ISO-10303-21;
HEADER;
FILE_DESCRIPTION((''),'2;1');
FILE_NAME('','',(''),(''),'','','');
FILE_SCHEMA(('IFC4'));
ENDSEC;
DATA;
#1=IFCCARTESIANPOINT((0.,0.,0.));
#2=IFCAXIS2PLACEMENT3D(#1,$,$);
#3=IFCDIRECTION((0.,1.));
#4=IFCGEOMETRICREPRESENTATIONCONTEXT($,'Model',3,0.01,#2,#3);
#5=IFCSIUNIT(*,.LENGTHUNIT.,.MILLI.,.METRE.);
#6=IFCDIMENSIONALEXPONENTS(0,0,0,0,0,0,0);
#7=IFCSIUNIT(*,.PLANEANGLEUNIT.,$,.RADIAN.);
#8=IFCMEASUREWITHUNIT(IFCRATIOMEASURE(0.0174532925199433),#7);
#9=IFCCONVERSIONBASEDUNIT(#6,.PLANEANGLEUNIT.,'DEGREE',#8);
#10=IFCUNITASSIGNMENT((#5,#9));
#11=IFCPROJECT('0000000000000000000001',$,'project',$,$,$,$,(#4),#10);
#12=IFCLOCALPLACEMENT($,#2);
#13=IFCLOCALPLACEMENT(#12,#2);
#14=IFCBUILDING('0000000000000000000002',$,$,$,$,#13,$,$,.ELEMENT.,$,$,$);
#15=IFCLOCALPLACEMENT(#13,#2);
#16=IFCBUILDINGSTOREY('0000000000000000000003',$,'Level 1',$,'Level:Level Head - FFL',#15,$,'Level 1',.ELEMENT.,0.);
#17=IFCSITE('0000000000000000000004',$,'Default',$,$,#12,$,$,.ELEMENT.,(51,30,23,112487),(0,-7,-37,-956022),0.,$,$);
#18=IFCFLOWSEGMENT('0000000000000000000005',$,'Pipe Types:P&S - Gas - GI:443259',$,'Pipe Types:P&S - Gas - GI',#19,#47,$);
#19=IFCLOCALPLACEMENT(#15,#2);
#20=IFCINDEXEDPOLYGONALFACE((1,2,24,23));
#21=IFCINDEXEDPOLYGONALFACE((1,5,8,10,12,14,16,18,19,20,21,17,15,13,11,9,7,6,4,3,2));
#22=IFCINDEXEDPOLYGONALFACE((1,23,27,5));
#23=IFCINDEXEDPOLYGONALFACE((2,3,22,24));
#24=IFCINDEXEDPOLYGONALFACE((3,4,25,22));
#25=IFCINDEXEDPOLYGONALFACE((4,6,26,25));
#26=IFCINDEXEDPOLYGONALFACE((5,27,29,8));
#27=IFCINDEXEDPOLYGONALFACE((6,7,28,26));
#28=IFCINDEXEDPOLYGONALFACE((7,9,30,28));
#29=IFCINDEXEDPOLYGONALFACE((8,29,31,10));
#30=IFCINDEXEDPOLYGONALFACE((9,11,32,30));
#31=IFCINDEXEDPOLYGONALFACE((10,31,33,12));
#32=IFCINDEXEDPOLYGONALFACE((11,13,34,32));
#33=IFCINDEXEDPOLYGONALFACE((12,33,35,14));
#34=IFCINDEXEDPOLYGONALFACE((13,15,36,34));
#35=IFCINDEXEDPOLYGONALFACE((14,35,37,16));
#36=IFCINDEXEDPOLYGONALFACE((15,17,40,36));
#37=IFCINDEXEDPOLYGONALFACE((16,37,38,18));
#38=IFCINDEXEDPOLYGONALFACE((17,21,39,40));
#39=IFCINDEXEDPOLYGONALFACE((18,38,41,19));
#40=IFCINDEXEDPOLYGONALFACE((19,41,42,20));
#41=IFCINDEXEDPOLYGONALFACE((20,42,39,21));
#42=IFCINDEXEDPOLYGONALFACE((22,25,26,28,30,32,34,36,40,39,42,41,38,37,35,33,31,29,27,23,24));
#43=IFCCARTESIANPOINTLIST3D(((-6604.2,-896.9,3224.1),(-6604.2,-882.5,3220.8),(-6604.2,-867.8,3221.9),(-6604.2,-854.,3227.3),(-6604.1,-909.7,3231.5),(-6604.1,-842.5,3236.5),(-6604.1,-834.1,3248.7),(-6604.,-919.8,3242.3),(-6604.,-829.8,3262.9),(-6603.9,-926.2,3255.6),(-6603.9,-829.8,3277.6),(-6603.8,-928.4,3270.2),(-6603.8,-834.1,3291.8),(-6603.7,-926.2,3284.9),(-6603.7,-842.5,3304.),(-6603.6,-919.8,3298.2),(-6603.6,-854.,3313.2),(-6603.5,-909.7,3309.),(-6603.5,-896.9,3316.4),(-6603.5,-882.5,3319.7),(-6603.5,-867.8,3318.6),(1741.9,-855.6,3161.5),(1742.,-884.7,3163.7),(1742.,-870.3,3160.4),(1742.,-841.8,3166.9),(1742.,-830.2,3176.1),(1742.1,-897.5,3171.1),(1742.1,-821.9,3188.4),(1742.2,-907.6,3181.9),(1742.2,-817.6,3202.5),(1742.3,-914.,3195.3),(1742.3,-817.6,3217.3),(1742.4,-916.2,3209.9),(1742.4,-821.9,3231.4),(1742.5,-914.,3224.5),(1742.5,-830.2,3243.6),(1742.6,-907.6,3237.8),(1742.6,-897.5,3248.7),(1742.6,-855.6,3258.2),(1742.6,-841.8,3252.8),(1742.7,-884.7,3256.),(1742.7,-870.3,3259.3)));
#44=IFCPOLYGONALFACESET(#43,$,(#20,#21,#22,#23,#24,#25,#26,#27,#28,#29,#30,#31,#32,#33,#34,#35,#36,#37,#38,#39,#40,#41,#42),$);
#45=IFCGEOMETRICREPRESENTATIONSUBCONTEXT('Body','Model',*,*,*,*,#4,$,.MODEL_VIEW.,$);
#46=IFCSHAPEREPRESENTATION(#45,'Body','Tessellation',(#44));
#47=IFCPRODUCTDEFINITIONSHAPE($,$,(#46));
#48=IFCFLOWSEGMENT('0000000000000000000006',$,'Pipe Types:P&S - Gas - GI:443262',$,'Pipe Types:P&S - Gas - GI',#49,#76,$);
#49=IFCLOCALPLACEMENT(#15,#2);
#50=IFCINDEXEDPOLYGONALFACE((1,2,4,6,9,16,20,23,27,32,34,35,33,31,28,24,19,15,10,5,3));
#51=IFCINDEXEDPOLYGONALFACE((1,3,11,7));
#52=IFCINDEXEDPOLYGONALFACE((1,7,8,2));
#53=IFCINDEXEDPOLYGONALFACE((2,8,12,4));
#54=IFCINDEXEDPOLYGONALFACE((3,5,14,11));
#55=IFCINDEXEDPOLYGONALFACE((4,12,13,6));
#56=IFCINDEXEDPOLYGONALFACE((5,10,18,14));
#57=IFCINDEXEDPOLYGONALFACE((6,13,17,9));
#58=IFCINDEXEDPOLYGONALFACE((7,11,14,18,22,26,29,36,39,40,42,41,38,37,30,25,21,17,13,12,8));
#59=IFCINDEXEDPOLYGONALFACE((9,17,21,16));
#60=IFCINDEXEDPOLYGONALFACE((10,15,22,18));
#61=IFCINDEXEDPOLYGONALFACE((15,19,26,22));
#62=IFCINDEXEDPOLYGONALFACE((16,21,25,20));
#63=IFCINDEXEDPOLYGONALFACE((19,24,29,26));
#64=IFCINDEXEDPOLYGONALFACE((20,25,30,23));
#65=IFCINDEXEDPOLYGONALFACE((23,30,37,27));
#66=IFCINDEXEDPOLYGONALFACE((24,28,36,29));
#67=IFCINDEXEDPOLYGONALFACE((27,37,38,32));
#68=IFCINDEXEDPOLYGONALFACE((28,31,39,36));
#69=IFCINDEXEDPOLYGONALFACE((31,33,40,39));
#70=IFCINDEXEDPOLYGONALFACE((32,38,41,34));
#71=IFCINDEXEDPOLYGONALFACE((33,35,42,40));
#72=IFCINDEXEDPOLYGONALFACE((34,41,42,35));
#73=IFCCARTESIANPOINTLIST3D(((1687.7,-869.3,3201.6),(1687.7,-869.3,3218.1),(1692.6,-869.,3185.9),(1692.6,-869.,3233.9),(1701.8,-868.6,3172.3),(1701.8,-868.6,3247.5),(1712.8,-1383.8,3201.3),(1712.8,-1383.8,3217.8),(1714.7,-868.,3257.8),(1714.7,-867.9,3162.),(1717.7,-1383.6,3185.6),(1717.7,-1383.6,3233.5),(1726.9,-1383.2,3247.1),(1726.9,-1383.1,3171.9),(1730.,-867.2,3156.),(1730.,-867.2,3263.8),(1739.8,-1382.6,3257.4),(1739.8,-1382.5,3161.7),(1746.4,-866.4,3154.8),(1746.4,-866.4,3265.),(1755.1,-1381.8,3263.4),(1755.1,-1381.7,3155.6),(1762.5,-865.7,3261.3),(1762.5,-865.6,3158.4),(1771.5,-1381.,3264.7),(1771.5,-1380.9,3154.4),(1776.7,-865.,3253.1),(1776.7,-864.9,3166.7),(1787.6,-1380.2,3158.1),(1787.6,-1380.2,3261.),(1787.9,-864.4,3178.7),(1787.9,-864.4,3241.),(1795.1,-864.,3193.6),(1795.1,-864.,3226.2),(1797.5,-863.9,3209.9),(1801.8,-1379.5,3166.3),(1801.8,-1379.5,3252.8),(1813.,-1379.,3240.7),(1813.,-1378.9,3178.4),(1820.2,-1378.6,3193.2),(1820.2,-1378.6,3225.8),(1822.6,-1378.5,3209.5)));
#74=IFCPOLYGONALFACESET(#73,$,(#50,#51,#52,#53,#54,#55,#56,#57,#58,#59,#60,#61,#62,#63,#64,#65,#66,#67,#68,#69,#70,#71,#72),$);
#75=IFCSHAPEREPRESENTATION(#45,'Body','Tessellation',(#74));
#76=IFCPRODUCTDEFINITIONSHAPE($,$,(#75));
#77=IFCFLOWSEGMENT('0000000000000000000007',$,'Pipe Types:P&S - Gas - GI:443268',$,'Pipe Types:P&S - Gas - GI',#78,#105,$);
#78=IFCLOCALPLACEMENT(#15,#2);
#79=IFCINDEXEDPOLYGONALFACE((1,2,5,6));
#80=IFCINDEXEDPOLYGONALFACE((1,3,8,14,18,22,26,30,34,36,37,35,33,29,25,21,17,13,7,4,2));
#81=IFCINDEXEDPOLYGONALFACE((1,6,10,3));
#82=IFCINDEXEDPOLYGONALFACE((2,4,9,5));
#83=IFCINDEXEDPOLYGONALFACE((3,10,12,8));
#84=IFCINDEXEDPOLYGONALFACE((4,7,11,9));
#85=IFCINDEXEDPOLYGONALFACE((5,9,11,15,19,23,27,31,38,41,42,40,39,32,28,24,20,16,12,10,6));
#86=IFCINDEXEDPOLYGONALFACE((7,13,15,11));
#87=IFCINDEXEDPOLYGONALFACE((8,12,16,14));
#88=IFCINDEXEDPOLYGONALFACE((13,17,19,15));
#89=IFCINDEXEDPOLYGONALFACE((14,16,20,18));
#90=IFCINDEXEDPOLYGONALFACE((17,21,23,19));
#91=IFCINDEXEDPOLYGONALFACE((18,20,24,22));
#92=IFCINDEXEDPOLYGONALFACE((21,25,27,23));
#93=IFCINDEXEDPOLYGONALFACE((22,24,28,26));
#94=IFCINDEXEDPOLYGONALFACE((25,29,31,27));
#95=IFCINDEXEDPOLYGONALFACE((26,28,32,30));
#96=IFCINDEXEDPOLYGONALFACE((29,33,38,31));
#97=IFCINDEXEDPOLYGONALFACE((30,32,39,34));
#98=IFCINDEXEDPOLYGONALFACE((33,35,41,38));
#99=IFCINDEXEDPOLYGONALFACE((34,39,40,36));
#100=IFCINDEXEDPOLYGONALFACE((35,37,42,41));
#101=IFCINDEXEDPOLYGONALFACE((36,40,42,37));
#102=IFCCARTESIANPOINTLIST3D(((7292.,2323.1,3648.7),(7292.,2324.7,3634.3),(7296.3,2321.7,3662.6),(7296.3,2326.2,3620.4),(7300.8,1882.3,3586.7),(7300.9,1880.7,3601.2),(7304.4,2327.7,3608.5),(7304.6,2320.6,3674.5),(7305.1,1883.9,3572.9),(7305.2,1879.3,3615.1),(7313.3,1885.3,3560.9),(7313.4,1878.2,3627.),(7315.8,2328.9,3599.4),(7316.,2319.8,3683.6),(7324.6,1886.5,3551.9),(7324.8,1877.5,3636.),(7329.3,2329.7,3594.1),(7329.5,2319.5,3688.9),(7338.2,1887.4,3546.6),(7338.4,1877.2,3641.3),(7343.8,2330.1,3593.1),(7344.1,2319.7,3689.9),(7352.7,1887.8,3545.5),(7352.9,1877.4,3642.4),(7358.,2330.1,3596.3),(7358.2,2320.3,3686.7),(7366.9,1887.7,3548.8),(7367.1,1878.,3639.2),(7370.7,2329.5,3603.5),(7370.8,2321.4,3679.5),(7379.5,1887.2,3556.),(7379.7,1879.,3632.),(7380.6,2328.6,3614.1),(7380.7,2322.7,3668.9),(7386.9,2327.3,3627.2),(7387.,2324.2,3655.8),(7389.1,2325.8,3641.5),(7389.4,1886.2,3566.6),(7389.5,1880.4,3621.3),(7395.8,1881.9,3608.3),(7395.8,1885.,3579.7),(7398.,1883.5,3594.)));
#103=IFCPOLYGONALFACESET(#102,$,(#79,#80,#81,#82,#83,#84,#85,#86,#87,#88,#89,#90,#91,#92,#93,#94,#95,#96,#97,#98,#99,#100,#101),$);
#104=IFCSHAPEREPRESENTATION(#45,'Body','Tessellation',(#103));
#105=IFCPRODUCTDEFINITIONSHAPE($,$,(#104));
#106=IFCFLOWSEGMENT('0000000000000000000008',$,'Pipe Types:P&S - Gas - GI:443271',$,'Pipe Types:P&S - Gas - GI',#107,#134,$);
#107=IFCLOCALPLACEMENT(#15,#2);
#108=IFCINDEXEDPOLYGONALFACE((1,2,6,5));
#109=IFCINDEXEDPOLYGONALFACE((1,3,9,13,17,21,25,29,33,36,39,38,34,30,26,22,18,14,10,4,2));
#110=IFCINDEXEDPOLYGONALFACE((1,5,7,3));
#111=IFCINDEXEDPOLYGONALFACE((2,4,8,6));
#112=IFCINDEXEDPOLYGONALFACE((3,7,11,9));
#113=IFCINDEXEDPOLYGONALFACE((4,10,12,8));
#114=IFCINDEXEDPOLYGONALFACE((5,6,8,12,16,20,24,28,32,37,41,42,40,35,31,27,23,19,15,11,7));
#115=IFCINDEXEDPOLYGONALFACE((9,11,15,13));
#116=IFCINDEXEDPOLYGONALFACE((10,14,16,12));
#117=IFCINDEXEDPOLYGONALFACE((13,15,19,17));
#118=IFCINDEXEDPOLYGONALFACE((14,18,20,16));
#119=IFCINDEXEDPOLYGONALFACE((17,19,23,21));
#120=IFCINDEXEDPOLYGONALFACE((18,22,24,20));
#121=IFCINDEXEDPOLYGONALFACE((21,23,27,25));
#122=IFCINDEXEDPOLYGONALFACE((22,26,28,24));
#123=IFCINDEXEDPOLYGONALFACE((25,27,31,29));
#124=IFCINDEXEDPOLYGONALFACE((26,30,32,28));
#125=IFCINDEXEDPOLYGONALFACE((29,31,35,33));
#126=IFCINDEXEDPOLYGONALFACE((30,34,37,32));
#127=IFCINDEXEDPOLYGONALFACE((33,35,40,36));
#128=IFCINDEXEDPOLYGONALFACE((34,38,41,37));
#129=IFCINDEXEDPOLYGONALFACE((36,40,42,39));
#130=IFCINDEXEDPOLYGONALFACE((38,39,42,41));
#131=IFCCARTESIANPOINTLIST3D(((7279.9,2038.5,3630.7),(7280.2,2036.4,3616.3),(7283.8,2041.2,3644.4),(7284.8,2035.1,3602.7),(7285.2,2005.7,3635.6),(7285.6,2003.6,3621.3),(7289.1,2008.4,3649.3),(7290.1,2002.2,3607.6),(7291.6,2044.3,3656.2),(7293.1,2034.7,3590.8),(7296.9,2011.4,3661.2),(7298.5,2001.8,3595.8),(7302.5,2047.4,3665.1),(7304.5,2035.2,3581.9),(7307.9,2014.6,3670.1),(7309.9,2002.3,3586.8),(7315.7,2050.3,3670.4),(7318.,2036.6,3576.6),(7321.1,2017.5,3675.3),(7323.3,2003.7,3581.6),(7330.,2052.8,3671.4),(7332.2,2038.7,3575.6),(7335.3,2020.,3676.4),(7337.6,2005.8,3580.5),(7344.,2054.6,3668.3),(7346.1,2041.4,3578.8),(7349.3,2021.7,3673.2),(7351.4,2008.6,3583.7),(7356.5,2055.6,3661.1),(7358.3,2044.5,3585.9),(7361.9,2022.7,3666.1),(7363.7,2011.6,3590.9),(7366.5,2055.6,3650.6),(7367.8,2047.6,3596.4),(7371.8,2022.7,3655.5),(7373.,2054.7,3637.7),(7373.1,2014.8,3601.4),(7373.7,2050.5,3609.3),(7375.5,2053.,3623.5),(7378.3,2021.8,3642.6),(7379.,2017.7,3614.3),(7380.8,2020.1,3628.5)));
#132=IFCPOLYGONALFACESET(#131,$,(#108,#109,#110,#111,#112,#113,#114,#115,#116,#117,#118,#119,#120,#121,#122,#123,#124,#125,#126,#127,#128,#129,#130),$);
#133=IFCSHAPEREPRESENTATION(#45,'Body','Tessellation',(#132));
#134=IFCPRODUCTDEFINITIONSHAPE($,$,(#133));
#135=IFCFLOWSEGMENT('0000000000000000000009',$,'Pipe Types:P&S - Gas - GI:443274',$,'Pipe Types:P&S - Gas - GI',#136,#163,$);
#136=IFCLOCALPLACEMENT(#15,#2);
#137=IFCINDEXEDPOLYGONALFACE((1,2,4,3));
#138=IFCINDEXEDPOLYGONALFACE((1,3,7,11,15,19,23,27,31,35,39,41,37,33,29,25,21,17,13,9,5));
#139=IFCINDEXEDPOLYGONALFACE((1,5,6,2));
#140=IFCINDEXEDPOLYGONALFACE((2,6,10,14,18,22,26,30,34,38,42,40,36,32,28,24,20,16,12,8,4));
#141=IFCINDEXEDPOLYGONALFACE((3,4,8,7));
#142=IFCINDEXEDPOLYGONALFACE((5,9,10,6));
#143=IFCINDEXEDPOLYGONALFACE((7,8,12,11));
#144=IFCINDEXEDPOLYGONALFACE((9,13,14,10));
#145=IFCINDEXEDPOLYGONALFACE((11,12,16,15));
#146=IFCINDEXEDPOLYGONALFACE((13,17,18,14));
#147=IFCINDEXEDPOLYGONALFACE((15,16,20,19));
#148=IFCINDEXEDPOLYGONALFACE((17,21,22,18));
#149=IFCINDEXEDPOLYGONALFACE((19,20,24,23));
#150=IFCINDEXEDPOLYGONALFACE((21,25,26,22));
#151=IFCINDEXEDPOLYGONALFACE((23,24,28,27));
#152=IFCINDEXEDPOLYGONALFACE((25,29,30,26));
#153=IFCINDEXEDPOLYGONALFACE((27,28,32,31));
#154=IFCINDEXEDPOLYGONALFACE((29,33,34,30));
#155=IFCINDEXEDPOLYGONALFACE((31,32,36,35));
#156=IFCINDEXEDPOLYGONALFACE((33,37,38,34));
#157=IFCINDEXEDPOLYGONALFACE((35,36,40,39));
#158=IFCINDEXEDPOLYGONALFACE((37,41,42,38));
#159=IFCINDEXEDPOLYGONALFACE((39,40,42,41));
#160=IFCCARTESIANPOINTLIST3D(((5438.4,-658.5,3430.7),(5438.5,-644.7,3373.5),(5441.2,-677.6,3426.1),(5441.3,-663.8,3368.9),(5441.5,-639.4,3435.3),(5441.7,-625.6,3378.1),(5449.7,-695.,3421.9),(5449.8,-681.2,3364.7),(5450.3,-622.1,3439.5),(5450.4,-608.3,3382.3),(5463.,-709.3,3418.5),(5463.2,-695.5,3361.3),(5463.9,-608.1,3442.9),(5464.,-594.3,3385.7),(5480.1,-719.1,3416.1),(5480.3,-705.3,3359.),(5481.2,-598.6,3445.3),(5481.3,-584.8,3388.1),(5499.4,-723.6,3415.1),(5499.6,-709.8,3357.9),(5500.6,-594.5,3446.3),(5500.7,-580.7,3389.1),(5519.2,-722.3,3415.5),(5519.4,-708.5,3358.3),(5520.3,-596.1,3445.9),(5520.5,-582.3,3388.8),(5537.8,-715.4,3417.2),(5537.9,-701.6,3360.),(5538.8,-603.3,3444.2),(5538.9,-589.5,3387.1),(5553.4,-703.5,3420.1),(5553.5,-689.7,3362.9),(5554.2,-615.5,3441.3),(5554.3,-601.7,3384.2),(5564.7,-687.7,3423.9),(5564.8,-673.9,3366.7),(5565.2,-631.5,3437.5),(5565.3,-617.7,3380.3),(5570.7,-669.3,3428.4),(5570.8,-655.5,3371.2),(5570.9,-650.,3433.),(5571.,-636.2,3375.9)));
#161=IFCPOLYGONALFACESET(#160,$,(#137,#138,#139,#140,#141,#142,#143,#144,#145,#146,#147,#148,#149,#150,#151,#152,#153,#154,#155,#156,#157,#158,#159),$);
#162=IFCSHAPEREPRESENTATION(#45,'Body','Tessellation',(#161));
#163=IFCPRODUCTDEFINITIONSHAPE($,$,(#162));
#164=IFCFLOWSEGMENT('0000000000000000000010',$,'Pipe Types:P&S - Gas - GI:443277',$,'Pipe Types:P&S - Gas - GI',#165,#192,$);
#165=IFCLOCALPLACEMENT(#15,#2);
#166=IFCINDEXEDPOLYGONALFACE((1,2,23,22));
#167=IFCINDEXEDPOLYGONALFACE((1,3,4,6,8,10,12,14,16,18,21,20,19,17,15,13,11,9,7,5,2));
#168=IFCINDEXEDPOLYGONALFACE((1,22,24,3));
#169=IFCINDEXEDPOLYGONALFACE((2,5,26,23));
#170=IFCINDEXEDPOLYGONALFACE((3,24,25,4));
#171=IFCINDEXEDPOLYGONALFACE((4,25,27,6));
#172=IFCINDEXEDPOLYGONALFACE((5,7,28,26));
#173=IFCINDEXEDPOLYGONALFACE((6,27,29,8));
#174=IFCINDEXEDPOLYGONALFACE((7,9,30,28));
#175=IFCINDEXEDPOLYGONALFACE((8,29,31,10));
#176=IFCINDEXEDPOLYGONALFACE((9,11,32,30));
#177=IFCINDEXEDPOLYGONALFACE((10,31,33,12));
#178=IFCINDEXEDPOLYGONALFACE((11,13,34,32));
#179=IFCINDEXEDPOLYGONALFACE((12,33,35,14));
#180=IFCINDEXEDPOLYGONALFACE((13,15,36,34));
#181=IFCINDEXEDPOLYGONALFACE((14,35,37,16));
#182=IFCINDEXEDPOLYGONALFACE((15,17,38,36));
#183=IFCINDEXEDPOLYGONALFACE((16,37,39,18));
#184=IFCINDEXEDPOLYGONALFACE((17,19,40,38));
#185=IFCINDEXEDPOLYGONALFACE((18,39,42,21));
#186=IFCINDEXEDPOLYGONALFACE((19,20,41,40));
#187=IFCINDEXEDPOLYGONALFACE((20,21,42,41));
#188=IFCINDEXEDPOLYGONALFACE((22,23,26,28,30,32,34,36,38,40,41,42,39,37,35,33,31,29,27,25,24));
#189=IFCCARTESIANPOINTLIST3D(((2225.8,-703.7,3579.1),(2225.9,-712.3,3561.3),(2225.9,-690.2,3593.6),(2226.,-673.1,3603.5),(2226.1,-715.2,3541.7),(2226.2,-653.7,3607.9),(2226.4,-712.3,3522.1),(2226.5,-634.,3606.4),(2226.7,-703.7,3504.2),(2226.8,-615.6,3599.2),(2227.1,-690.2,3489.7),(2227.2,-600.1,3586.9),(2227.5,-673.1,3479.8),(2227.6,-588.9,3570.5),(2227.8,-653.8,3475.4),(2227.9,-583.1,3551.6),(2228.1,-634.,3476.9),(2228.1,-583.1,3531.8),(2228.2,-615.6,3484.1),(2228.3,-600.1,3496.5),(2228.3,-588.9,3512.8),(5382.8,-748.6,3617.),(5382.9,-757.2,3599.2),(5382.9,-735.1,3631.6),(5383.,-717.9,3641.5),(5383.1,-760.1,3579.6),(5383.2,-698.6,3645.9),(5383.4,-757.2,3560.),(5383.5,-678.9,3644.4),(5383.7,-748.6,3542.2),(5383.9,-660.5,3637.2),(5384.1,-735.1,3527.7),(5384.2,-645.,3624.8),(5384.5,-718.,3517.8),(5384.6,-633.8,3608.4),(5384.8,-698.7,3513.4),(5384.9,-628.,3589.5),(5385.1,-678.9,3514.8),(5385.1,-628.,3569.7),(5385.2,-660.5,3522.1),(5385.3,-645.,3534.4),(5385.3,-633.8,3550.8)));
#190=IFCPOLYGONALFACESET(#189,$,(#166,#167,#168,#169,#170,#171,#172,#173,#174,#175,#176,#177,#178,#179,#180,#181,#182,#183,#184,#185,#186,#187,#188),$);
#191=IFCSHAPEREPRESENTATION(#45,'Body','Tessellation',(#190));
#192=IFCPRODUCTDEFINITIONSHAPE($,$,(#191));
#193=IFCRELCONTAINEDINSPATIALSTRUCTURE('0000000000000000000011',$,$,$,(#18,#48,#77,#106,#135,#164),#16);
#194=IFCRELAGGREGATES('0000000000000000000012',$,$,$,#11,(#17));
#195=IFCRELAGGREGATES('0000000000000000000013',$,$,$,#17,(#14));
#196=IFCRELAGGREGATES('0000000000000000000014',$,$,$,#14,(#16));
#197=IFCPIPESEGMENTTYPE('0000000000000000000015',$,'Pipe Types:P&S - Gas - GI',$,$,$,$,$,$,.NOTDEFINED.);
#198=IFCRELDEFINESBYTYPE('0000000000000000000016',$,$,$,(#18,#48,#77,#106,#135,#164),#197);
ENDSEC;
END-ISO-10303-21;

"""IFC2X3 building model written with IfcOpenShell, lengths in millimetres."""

from ifc_helpers import new_model, entity, si_unit, converted_unit, direction, frame, frame_2d, origin, origin_2d_with_axis, place, context, subcontext, project, spatial, circle, extrude, type_object, element, save


model = new_model("IFC2X3")

# Units and contexts
model_context = context("Model", 3, precision=0.01, world=origin(), true_north=direction((0.0, 1.0)))
body_context = subcontext(model_context, "Body", "Model", "MODEL_VIEW")
ifc_project = project(units=[si_unit("LENGTHUNIT", "METRE", prefix="MILLI"), converted_unit("PLANEANGLEUNIT", "DEGREE", entity("IfcRatioMeasure", 0.0174532925199433), si_unit("PLANEANGLEUNIT", "RADIAN"), dimensions=[0, 0, 0, 0, 0, 0, 0])], contexts=[model_context])

# Site, building, storey
site_placement = place(None, origin())
site = spatial("IfcSite", under=ifc_project, at=site_placement, Name="Default", CompositionType="ELEMENT", RefLatitude=(51, 30, 23, 112487), RefLongitude=(0, -7, -37, -956022), RefElevation=0.0)
building_placement = place(site_placement, origin())
building = spatial("IfcBuilding", under=site, at=building_placement, CompositionType="ELEMENT")
storey_placement = place(building_placement, origin())
storey = spatial("IfcBuildingStorey", under=building, at=storey_placement, Name="Level 1", ObjectType="Level:Level Head - FFL", LongName="Level 1", CompositionType="ELEMENT", Elevation=0.0)

# Flow segments
pipe_segment_type = type_object("IfcPipeSegmentType", Name="Pipe Types:P&S - Gas - GI", PredefinedType="NOTDEFINED")
flow_segment_1_placement = place(storey_placement, origin())
element("IfcFlowSegment", 1, at=flow_segment_1_placement, inside=storey, type_object=pipe_segment_type, Name="Pipe Types:P&S - Gas - GI:443259", ObjectType="Pipe Types:P&S - Gas - GI", context=body_context, shape_type="SweptSolid", body=[
    extrude(circle(Radius=49.6, at=frame_2d((0.0, 0.0), x_axis=(1.0, 0.0))), frame((-6603.8, -878.8, 3270.2), z_axis=(0.999973, 0.001464, -0.007233), x_axis=(0.001464, -0.999999, 0.0)), (0.0, 0.0, 1.0), 8346.4),
])
flow_segment_2_placement = place(storey_placement, origin())
element("IfcFlowSegment", 2, at=flow_segment_2_placement, inside=storey, type_object=pipe_segment_type, Name="Pipe Types:P&S - Gas - GI:443262", ObjectType="Pipe Types:P&S - Gas - GI", context=body_context, shape_type="SweptSolid", body=[
    extrude(circle(Radius=55.3, at=frame_2d((0.0, 0.0), x_axis=(1.0, 0.0))), frame((1767.4, -1381.2, 3209.5), z_axis=(-0.048735, 0.998812, 0.000662), x_axis=(0.998812, 0.048735, 0.0)), (0.0, 0.0, 1.0), 515.2),
])
flow_segment_3_placement = place(storey_placement, origin())
element("IfcFlowSegment", 3, at=flow_segment_3_placement, inside=storey, type_object=pipe_segment_type, Name="Pipe Types:P&S - Gas - GI:443268", ObjectType="Pipe Types:P&S - Gas - GI", context=body_context, shape_type="SweptSolid", body=[
    extrude(circle(Radius=48.8, at=frame_2d((0.0, 0.0), x_axis=(1.0, 0.0))), frame((7349.1, 1882.5, 3594.0), z_axis=(-0.019849, 0.994083, 0.106793), x_axis=(0.999801, 0.019963, 0.0)), (0.0, 0.0, 1.0), 445.0),
])
flow_segment_4_placement = place(storey_placement, origin())
element("IfcFlowSegment", 4, at=flow_segment_4_placement, inside=storey, type_object=pipe_segment_type, Name="Pipe Types:P&S - Gas - GI:443271", ObjectType="Pipe Types:P&S - Gas - GI", context=body_context, shape_type="SweptSolid", body=[
    extrude(circle(Radius=48.6, at=origin_2d_with_axis()), frame((7332.8, 2012.3, 3628.5), z_axis=(-0.158478, 0.976294, -0.147426), x_axis=(0.98708, 0.160229, 0.0)), (0.0, 0.0, 1.0), 33.7),
])
flow_segment_5_placement = place(storey_placement, origin())
element("IfcFlowSegment", 5, at=flow_segment_5_placement, inside=storey, type_object=pipe_segment_type, Name="Pipe Types:P&S - Gas - GI:443274", ObjectType="Pipe Types:P&S - Gas - GI", context=body_context, shape_type="SweptSolid", body=[
    extrude(circle(Radius=66.6, at=origin_2d_with_axis()), frame((5505.0, -659.1, 3430.7), z_axis=(0.00205, 0.234799, -0.972042), x_axis=(-0.999962, 0.008729, 0.0)), (0.0, 0.0, 1.0), 58.8),
])
flow_segment_6_placement = place(storey_placement, origin())
element("IfcFlowSegment", 6, at=flow_segment_6_placement, inside=storey, type_object=pipe_segment_type, Name="Pipe Types:P&S - Gas - GI:443277", ObjectType="Pipe Types:P&S - Gas - GI", context=body_context, shape_type="SweptSolid", body=[
    extrude(circle(Radius=66.4, at=frame_2d((0.0, 0.0), x_axis=(1.0, 0.0))), frame((2227.1, -648.8, 3541.7), z_axis=(0.999827, -0.014217, 0.012018), x_axis=(-0.014218, -0.999899, 0.0)), (0.0, 0.0, 1.0), 3157.6),
])

save(model, "model.ifc")
